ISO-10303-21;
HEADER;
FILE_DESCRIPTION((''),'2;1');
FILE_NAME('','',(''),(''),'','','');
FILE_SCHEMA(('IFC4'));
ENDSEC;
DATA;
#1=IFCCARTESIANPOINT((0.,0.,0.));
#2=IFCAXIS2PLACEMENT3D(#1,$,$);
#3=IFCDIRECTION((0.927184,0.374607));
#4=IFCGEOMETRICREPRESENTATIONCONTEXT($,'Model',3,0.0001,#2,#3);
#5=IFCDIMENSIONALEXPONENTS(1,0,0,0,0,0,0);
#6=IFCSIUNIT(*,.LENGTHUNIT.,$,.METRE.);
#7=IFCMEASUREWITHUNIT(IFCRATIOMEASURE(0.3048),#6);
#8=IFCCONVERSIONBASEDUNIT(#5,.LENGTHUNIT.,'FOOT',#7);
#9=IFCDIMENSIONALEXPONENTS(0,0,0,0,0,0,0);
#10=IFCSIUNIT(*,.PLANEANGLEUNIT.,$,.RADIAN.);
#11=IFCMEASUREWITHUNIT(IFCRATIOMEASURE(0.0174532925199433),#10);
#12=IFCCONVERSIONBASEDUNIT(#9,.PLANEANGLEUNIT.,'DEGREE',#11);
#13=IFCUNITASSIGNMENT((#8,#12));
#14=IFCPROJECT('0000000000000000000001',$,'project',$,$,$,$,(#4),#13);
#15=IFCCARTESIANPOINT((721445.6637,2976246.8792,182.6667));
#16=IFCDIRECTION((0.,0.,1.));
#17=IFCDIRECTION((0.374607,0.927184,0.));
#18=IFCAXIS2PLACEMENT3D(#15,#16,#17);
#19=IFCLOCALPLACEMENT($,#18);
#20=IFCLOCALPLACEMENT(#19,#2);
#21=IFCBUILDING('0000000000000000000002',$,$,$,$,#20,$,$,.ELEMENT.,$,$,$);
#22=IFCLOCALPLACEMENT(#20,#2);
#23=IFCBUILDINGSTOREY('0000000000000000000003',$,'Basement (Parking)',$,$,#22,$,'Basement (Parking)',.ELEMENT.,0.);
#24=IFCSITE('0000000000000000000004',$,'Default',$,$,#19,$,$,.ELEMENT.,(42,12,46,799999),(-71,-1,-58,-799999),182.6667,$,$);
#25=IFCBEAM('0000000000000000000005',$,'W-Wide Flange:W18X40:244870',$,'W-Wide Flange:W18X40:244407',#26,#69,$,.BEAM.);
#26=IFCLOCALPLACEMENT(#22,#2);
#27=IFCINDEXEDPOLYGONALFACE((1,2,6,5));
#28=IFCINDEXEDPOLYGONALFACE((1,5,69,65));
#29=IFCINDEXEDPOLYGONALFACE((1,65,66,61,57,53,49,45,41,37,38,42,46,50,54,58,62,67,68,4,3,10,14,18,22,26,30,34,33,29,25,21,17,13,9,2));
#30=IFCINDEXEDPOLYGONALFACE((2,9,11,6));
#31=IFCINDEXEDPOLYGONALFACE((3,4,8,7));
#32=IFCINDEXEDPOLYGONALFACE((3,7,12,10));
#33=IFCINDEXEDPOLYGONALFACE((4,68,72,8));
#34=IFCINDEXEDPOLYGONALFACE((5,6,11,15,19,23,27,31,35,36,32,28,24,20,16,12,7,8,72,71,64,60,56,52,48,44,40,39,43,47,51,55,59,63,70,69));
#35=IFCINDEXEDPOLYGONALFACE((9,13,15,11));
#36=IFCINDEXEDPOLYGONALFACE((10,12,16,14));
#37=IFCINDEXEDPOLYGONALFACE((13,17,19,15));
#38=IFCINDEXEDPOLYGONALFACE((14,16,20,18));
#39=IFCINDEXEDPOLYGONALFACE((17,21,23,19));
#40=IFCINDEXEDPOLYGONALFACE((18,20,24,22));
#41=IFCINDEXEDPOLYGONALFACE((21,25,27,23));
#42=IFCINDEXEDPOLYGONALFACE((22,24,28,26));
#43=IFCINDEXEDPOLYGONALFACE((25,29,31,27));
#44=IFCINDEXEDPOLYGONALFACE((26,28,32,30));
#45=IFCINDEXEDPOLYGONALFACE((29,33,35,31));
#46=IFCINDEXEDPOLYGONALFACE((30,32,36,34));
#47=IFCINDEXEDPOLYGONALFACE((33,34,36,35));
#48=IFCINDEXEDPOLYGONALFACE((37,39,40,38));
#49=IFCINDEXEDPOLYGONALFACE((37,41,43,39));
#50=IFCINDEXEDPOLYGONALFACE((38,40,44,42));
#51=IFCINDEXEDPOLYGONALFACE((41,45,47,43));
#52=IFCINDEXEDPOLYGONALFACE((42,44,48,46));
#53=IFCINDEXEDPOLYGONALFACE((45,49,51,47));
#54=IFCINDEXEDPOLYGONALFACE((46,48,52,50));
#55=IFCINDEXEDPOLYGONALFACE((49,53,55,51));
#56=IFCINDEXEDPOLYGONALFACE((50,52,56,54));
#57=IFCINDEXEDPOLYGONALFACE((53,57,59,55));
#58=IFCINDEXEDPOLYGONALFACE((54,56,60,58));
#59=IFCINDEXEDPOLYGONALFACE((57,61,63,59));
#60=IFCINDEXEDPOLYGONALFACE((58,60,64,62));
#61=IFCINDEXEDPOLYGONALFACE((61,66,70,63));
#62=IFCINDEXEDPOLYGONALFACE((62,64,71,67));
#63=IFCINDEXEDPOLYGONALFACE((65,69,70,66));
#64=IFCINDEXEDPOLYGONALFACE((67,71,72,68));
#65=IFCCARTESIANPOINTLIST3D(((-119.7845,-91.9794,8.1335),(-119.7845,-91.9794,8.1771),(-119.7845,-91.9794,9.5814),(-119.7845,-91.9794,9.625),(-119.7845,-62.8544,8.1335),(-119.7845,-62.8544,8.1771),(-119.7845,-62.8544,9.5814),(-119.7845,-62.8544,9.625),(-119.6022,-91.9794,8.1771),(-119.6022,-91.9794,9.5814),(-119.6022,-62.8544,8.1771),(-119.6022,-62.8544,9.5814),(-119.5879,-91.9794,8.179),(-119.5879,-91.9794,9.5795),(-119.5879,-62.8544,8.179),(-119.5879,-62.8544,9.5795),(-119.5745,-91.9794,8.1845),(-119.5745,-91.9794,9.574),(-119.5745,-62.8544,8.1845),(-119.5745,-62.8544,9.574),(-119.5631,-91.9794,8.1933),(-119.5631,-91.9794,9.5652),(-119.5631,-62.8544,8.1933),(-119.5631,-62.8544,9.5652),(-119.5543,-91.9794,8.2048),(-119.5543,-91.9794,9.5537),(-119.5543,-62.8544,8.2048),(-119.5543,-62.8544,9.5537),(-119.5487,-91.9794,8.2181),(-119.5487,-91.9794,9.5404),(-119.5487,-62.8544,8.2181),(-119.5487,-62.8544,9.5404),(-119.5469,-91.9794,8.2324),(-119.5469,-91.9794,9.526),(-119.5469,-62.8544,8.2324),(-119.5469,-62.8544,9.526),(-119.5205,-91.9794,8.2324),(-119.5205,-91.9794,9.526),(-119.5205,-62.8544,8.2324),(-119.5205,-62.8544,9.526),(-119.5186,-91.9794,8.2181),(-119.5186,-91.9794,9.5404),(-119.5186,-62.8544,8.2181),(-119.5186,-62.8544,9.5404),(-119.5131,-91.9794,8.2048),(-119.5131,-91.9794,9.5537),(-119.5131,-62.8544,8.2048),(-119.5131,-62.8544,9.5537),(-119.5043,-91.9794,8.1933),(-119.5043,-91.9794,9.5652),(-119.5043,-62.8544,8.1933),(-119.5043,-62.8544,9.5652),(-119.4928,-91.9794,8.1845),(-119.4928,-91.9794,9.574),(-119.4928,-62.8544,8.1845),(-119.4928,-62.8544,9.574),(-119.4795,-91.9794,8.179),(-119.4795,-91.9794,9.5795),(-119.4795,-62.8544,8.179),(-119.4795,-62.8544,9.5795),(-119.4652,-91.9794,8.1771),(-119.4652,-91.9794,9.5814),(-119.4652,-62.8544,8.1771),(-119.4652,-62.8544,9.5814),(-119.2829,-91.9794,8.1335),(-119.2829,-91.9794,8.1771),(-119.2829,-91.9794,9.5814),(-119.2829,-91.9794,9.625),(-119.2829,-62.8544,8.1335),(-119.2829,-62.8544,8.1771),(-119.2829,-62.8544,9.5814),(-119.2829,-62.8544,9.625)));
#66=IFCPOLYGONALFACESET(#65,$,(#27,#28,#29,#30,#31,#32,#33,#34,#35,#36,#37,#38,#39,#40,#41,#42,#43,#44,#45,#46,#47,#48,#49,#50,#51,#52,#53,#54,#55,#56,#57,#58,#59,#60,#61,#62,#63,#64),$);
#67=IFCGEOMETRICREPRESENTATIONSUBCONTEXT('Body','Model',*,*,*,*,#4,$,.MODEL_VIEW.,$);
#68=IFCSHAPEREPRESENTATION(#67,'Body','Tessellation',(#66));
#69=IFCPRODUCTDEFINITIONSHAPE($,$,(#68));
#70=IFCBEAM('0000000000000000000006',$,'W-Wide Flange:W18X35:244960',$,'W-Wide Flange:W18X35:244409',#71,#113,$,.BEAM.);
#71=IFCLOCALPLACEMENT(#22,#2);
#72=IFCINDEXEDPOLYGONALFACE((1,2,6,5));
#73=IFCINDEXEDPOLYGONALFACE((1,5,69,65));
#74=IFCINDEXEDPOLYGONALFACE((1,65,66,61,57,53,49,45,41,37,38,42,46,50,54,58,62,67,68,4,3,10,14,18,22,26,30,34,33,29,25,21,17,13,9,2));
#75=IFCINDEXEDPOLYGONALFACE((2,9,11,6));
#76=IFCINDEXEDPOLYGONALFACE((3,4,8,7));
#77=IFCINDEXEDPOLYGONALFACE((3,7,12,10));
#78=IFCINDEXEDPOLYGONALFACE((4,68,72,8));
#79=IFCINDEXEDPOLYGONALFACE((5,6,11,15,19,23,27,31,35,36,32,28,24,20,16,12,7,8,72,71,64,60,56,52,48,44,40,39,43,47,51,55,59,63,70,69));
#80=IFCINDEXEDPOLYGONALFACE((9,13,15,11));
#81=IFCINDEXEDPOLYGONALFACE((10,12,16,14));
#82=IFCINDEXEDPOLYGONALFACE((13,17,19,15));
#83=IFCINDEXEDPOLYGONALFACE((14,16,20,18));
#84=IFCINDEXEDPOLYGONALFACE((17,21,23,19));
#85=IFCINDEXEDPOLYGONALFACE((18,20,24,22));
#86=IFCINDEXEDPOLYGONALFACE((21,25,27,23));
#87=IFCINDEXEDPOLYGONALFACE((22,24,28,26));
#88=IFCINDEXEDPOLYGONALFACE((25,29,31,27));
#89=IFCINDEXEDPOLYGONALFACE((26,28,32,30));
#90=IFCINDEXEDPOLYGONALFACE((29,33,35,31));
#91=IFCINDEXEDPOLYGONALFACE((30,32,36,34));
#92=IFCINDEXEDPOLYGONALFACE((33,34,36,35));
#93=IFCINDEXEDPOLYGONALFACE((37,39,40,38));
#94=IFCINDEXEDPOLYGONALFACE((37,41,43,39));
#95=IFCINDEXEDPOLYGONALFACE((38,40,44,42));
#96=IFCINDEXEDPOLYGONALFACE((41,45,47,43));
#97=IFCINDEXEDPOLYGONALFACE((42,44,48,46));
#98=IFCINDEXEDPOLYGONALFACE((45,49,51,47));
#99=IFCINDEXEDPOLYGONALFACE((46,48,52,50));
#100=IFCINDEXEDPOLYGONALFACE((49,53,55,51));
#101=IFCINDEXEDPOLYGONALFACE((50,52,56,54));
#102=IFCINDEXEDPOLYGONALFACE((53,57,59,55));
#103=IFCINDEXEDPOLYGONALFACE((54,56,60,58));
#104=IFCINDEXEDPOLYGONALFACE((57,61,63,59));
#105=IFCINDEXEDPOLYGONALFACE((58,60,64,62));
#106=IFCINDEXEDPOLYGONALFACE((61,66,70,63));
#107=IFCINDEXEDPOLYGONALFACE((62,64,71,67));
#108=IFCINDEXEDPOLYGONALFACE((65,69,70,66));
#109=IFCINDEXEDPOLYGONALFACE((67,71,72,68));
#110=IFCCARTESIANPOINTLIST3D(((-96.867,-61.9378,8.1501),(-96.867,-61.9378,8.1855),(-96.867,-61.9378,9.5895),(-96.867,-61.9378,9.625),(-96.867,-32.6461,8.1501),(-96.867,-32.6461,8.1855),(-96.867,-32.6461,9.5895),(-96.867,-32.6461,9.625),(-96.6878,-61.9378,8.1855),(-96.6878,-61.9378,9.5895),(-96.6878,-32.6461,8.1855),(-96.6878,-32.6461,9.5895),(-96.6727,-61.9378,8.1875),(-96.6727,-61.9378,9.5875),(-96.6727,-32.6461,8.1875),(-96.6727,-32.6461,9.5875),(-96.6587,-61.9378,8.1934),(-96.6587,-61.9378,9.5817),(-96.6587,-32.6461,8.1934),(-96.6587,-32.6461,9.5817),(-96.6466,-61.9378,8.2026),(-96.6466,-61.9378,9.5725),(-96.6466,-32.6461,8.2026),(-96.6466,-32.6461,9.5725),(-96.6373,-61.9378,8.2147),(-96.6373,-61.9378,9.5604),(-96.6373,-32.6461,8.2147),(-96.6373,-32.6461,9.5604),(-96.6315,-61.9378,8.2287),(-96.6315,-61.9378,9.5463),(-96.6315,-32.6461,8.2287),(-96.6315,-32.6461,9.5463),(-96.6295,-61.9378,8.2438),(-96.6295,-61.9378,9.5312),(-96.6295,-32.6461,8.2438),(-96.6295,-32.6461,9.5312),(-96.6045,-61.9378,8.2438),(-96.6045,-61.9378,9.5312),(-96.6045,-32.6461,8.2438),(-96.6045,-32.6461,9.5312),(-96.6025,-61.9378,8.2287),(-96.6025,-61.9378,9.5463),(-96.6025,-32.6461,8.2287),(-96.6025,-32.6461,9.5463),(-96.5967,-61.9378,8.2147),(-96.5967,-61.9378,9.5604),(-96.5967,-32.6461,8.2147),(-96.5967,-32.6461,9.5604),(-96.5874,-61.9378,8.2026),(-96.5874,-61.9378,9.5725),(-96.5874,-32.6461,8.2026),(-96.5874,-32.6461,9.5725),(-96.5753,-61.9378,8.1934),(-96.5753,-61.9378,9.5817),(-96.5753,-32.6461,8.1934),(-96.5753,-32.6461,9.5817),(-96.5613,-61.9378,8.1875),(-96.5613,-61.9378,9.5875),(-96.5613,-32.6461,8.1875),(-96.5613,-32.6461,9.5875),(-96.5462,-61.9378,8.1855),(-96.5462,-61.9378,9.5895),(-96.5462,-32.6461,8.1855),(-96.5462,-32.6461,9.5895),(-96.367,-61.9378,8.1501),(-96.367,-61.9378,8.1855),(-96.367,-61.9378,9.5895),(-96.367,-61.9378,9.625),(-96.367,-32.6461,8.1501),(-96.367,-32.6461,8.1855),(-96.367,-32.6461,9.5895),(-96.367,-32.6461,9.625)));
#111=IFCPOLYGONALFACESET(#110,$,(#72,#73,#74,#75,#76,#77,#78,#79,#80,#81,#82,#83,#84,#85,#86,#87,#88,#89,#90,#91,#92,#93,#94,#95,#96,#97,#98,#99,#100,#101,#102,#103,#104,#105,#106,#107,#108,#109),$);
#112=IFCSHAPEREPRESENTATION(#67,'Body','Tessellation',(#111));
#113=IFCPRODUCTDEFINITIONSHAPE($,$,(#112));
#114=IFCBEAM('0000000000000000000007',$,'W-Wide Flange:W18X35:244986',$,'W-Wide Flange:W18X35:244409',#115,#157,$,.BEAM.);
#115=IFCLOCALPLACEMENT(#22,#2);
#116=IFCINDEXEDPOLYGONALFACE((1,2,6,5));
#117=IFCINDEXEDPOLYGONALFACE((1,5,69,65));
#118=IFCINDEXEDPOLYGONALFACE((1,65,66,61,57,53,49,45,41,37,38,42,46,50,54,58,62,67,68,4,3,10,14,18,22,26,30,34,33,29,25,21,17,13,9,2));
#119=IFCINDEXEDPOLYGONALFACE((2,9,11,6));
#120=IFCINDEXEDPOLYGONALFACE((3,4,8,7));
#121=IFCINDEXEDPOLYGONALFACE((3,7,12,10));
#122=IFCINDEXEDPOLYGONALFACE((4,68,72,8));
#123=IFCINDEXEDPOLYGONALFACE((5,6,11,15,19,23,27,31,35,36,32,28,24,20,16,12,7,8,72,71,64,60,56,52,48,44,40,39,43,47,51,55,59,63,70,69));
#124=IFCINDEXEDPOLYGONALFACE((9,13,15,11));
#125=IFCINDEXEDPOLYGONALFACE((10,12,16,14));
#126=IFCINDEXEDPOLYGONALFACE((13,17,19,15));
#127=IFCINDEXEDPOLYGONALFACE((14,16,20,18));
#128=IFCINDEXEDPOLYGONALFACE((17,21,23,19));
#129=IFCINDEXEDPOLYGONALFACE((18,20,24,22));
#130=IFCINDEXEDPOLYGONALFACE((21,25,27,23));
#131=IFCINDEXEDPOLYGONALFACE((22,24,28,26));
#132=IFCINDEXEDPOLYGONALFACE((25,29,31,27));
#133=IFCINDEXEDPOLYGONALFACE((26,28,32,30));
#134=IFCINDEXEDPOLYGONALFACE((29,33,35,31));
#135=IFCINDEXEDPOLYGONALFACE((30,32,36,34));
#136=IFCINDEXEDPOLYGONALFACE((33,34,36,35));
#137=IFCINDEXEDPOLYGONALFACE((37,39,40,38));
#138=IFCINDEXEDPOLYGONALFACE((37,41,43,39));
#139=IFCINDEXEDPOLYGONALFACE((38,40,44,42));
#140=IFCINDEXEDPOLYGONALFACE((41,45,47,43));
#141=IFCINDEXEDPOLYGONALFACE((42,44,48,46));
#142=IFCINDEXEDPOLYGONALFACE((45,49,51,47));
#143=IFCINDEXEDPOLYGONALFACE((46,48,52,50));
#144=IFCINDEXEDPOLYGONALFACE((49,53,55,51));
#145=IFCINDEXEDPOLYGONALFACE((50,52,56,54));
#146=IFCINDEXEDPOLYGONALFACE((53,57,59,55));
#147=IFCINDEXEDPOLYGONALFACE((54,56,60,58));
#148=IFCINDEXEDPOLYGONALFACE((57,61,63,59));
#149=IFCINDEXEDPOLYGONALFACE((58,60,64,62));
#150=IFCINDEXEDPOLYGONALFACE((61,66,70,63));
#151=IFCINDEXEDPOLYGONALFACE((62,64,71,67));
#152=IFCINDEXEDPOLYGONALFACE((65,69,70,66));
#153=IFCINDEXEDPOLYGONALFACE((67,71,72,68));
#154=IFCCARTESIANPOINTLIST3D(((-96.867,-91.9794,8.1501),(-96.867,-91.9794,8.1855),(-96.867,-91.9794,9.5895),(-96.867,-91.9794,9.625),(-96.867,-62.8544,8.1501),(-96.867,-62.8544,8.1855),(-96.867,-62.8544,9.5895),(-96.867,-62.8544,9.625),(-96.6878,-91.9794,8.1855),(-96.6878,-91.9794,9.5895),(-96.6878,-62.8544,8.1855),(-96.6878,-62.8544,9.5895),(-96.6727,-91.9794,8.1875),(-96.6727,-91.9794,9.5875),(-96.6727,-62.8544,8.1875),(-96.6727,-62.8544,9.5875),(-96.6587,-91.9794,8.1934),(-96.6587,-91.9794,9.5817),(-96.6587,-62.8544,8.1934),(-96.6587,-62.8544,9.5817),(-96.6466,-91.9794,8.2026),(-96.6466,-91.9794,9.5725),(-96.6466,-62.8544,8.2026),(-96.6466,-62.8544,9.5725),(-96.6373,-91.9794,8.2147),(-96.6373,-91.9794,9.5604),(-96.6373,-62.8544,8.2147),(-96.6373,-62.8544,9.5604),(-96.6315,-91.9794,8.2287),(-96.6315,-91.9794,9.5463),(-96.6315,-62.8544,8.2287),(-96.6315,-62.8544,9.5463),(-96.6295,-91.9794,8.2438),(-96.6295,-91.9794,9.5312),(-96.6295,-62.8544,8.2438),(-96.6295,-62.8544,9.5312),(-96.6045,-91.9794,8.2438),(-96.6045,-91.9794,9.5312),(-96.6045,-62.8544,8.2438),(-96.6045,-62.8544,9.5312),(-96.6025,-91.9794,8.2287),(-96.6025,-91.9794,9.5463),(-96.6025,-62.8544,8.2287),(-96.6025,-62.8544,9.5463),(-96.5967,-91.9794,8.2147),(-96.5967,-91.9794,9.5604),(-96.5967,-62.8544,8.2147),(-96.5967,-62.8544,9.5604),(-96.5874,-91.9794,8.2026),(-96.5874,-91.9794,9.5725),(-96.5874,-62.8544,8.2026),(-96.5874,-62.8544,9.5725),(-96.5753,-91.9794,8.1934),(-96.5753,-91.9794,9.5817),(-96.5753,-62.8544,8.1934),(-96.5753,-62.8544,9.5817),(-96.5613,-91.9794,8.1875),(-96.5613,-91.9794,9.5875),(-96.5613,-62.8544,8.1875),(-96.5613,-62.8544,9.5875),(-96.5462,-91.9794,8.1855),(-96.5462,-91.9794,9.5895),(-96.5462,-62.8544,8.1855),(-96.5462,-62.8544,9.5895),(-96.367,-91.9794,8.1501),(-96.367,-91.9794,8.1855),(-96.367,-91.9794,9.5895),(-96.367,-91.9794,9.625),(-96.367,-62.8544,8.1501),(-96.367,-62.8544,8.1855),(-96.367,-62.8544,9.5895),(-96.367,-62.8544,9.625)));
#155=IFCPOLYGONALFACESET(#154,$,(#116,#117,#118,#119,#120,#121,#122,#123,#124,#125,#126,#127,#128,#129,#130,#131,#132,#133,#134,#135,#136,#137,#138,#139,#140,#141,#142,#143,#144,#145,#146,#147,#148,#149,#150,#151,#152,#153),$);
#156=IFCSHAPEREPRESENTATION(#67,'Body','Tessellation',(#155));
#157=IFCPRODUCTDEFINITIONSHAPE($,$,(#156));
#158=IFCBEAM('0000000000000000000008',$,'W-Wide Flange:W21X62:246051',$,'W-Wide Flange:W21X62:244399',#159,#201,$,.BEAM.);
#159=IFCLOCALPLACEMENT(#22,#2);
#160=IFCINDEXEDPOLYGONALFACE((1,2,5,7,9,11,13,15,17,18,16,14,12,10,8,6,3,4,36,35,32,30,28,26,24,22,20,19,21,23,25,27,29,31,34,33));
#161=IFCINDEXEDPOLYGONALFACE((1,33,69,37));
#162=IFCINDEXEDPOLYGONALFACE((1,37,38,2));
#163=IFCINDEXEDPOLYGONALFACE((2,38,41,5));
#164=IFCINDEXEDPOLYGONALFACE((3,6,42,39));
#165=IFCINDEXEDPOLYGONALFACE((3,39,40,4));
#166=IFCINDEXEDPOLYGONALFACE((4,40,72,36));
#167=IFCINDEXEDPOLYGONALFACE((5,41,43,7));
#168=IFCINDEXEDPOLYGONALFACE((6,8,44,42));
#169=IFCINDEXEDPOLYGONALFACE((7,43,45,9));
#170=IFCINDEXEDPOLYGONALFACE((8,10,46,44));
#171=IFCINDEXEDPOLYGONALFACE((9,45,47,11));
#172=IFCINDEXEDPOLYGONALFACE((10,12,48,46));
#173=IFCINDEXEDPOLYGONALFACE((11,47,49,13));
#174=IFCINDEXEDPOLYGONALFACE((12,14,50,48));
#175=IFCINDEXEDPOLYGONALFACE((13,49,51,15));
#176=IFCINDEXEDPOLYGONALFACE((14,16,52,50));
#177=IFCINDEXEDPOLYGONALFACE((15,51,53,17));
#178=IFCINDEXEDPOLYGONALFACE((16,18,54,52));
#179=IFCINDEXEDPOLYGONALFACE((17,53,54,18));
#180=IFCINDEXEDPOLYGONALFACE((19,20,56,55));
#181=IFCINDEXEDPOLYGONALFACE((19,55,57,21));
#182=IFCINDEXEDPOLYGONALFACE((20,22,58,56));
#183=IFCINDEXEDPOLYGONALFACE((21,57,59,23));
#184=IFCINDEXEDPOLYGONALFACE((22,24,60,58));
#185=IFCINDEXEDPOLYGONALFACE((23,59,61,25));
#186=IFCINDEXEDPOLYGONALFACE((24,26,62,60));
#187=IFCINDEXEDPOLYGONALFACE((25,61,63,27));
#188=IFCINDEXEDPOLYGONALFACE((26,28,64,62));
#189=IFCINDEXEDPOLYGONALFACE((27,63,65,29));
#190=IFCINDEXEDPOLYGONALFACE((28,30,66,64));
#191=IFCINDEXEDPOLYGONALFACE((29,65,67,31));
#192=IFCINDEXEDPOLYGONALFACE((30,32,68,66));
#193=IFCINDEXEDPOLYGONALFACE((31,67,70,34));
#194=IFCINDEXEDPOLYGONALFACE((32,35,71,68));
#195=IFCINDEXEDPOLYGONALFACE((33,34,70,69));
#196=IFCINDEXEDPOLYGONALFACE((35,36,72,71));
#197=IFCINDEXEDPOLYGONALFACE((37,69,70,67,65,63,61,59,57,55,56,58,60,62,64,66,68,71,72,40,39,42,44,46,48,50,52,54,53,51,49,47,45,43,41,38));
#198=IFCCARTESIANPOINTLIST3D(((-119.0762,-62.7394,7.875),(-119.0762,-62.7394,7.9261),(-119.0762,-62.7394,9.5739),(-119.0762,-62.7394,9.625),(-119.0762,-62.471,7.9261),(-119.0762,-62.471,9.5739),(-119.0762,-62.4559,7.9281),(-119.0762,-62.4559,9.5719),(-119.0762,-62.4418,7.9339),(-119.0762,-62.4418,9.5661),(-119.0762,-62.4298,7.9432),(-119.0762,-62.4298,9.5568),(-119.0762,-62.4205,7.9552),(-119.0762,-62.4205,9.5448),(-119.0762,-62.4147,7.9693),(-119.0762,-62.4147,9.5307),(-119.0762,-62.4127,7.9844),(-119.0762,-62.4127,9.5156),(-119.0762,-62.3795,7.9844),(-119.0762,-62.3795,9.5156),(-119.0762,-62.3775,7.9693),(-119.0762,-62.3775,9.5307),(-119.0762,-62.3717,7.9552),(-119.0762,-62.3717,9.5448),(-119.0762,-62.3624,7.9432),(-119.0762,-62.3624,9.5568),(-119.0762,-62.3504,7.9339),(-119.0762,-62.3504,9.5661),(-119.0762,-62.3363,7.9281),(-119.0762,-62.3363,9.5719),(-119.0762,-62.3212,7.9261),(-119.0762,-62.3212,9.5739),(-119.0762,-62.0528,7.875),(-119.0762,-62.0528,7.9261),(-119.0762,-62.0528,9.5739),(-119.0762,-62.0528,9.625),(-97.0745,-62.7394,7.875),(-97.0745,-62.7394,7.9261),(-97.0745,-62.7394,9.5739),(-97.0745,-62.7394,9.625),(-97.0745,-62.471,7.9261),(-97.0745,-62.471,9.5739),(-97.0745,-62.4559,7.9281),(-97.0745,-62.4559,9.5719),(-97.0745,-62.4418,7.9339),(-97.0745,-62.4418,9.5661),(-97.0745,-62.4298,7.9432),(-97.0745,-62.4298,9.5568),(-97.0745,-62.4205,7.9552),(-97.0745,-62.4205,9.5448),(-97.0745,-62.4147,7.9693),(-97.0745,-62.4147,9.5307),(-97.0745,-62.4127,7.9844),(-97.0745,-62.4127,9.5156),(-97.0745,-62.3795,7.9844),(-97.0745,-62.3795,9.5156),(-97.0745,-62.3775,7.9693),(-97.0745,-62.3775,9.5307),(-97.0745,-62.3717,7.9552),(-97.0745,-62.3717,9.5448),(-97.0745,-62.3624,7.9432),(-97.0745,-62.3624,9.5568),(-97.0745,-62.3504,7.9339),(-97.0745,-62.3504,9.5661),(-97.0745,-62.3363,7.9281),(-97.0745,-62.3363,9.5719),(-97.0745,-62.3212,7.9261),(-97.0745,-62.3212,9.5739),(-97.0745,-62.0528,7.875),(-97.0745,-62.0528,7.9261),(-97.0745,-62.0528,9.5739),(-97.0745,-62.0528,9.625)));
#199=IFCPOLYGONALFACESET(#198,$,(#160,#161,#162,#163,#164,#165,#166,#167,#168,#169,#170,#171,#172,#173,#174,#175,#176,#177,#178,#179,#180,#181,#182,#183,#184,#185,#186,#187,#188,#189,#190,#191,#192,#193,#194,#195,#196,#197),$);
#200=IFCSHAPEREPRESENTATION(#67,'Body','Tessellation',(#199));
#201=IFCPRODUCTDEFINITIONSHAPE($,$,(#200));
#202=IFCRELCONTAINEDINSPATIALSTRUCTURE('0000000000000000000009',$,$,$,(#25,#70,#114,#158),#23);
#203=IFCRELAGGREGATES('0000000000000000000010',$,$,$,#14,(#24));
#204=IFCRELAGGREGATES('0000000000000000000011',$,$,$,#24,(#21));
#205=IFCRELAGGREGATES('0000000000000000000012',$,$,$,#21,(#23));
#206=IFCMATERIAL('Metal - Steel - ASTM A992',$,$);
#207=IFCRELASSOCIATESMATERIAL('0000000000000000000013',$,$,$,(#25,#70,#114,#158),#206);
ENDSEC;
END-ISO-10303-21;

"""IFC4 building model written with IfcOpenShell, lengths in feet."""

from ifc_helpers import new_model, entity, si_unit, converted_unit, direction, frame, frame_2d, origin, place, context, subcontext, project, spatial, i_section, extrude, material, element, save


model = new_model("IFC4")

# Units and contexts
model_context = context("Model", 3, precision=0.0001, world=origin(), true_north=direction((0.927184, 0.374607)))
body_context = subcontext(model_context, "Body", "Model", "MODEL_VIEW")
ifc_project = project(units=[converted_unit("LENGTHUNIT", "FOOT", entity("IfcRatioMeasure", 0.3048), si_unit("LENGTHUNIT", "METRE"), dimensions=[1, 0, 0, 0, 0, 0, 0]), converted_unit("PLANEANGLEUNIT", "DEGREE", entity("IfcRatioMeasure", 0.0174532925199433), si_unit("PLANEANGLEUNIT", "RADIAN"), dimensions=[0, 0, 0, 0, 0, 0, 0])], contexts=[model_context])

# Site, building, storey
site_placement = place(None, frame((721445.6637, 2976246.8792, 182.6667), z_axis=(0.0, 0.0, 1.0), x_axis=(0.374607, 0.927184, 0.0)))
site = spatial("IfcSite", under=ifc_project, at=site_placement, Name="Default", CompositionType="ELEMENT", RefLatitude=(42, 12, 46, 799999), RefLongitude=(-71, -1, -58, -799999), RefElevation=182.6667)
building_placement = place(site_placement, origin())
building = spatial("IfcBuilding", under=site, at=building_placement, CompositionType="ELEMENT")
storey_placement = place(building_placement, origin())
storey = spatial("IfcBuildingStorey", under=building, at=storey_placement, Name="Basement (Parking)", LongName="Basement (Parking)", CompositionType="ELEMENT", Elevation=0.0)

# Shared definitions
ifc_material_1 = material(Name="Metal - Steel - ASTM A992")

# Beams
beam_1_placement = place(storey_placement, frame((-119.5337, -92.4378, 9.625), z_axis=(0.0, 0.0, 1.0), x_axis=(0.0, 1.0, 0.0)))
element("IfcBeam", 1, at=beam_1_placement, inside=storey, material=ifc_material_1, Name="W-Wide Flange:W18X40:244870", ObjectType="W-Wide Flange:W18X40:244407", PredefinedType="BEAM", context=body_context, shape_type="SweptSolid", body=[
    extrude(i_section(OverallWidth=0.5016, OverallDepth=1.4915, WebThickness=0.0264, FlangeThickness=0.0436, FilletRadius=0.0553, at=frame_2d((0.0, 0.0), x_axis=(0.0, 1.0))), frame((0.4583, 0.0, -0.7458), z_axis=(1.0, 0.0, 0.0), x_axis=(0.0, 0.0, -1.0)), (0.0, 0.0, 1.0), 29.125),
])
beam_2_placement = place(storey_placement, frame((-96.617, -62.3961, 9.625), z_axis=(0.0, 0.0, 1.0), x_axis=(0.0, 1.0, 0.0)))
element("IfcBeam", 2, at=beam_2_placement, inside=storey, material=ifc_material_1, Name="W-Wide Flange:W18X35:244960", ObjectType="W-Wide Flange:W18X35:244409", PredefinedType="BEAM", context=body_context, shape_type="SweptSolid", body=[
    extrude(i_section(OverallWidth=0.5, OverallDepth=1.4749, WebThickness=0.0251, FlangeThickness=0.0355, FilletRadius=0.0583, at=frame_2d((0.0, 0.0), x_axis=(0.0, 1.0))), frame((0.4583, 0.0, -0.7375), z_axis=(1.0, 0.0, 0.0), x_axis=(0.0, 0.0, -1.0)), (0.0, 0.0, 1.0), 29.2917),
])
beam_3_placement = place(storey_placement, frame((-96.617, -62.3961, 9.625), z_axis=(0.0, 0.0, 1.0), x_axis=(0.0, -1.0, 0.0)))
element("IfcBeam", 3, at=beam_3_placement, inside=storey, material=ifc_material_1, Name="W-Wide Flange:W18X35:244986", ObjectType="W-Wide Flange:W18X35:244409", PredefinedType="BEAM", context=body_context, shape_type="SweptSolid", body=[
    extrude(i_section(OverallWidth=0.5, OverallDepth=1.4749, WebThickness=0.0251, FlangeThickness=0.0355, FilletRadius=0.0583, at=frame_2d((0.0, 0.0), x_axis=(0.0, 1.0))), frame((0.4583, 0.0, -0.7375), z_axis=(1.0, 0.0, 0.0), x_axis=(0.0, 0.0, -1.0)), (0.0, 0.0, 1.0), 29.125),
])
beam_4_placement = place(storey_placement, frame((-119.5337, -62.3961, 9.625)))
element("IfcBeam", 4, at=beam_4_placement, inside=storey, material=ifc_material_1, Name="W-Wide Flange:W21X62:246051", ObjectType="W-Wide Flange:W21X62:244399", PredefinedType="BEAM", context=body_context, shape_type="SweptSolid", body=[
    extrude(i_section(OverallWidth=0.6865, OverallDepth=1.75, WebThickness=0.0332, FlangeThickness=0.0511, FilletRadius=0.0583, at=frame_2d((0.0, 0.0), x_axis=(0.0, 1.0))), frame((0.4575, 0.0, -0.875), z_axis=(1.0, 0.0, 0.0), x_axis=(0.0, 0.0, -1.0)), (0.0, 0.0, 1.0), 22.0016),
])

save(model, "model.ifc")
